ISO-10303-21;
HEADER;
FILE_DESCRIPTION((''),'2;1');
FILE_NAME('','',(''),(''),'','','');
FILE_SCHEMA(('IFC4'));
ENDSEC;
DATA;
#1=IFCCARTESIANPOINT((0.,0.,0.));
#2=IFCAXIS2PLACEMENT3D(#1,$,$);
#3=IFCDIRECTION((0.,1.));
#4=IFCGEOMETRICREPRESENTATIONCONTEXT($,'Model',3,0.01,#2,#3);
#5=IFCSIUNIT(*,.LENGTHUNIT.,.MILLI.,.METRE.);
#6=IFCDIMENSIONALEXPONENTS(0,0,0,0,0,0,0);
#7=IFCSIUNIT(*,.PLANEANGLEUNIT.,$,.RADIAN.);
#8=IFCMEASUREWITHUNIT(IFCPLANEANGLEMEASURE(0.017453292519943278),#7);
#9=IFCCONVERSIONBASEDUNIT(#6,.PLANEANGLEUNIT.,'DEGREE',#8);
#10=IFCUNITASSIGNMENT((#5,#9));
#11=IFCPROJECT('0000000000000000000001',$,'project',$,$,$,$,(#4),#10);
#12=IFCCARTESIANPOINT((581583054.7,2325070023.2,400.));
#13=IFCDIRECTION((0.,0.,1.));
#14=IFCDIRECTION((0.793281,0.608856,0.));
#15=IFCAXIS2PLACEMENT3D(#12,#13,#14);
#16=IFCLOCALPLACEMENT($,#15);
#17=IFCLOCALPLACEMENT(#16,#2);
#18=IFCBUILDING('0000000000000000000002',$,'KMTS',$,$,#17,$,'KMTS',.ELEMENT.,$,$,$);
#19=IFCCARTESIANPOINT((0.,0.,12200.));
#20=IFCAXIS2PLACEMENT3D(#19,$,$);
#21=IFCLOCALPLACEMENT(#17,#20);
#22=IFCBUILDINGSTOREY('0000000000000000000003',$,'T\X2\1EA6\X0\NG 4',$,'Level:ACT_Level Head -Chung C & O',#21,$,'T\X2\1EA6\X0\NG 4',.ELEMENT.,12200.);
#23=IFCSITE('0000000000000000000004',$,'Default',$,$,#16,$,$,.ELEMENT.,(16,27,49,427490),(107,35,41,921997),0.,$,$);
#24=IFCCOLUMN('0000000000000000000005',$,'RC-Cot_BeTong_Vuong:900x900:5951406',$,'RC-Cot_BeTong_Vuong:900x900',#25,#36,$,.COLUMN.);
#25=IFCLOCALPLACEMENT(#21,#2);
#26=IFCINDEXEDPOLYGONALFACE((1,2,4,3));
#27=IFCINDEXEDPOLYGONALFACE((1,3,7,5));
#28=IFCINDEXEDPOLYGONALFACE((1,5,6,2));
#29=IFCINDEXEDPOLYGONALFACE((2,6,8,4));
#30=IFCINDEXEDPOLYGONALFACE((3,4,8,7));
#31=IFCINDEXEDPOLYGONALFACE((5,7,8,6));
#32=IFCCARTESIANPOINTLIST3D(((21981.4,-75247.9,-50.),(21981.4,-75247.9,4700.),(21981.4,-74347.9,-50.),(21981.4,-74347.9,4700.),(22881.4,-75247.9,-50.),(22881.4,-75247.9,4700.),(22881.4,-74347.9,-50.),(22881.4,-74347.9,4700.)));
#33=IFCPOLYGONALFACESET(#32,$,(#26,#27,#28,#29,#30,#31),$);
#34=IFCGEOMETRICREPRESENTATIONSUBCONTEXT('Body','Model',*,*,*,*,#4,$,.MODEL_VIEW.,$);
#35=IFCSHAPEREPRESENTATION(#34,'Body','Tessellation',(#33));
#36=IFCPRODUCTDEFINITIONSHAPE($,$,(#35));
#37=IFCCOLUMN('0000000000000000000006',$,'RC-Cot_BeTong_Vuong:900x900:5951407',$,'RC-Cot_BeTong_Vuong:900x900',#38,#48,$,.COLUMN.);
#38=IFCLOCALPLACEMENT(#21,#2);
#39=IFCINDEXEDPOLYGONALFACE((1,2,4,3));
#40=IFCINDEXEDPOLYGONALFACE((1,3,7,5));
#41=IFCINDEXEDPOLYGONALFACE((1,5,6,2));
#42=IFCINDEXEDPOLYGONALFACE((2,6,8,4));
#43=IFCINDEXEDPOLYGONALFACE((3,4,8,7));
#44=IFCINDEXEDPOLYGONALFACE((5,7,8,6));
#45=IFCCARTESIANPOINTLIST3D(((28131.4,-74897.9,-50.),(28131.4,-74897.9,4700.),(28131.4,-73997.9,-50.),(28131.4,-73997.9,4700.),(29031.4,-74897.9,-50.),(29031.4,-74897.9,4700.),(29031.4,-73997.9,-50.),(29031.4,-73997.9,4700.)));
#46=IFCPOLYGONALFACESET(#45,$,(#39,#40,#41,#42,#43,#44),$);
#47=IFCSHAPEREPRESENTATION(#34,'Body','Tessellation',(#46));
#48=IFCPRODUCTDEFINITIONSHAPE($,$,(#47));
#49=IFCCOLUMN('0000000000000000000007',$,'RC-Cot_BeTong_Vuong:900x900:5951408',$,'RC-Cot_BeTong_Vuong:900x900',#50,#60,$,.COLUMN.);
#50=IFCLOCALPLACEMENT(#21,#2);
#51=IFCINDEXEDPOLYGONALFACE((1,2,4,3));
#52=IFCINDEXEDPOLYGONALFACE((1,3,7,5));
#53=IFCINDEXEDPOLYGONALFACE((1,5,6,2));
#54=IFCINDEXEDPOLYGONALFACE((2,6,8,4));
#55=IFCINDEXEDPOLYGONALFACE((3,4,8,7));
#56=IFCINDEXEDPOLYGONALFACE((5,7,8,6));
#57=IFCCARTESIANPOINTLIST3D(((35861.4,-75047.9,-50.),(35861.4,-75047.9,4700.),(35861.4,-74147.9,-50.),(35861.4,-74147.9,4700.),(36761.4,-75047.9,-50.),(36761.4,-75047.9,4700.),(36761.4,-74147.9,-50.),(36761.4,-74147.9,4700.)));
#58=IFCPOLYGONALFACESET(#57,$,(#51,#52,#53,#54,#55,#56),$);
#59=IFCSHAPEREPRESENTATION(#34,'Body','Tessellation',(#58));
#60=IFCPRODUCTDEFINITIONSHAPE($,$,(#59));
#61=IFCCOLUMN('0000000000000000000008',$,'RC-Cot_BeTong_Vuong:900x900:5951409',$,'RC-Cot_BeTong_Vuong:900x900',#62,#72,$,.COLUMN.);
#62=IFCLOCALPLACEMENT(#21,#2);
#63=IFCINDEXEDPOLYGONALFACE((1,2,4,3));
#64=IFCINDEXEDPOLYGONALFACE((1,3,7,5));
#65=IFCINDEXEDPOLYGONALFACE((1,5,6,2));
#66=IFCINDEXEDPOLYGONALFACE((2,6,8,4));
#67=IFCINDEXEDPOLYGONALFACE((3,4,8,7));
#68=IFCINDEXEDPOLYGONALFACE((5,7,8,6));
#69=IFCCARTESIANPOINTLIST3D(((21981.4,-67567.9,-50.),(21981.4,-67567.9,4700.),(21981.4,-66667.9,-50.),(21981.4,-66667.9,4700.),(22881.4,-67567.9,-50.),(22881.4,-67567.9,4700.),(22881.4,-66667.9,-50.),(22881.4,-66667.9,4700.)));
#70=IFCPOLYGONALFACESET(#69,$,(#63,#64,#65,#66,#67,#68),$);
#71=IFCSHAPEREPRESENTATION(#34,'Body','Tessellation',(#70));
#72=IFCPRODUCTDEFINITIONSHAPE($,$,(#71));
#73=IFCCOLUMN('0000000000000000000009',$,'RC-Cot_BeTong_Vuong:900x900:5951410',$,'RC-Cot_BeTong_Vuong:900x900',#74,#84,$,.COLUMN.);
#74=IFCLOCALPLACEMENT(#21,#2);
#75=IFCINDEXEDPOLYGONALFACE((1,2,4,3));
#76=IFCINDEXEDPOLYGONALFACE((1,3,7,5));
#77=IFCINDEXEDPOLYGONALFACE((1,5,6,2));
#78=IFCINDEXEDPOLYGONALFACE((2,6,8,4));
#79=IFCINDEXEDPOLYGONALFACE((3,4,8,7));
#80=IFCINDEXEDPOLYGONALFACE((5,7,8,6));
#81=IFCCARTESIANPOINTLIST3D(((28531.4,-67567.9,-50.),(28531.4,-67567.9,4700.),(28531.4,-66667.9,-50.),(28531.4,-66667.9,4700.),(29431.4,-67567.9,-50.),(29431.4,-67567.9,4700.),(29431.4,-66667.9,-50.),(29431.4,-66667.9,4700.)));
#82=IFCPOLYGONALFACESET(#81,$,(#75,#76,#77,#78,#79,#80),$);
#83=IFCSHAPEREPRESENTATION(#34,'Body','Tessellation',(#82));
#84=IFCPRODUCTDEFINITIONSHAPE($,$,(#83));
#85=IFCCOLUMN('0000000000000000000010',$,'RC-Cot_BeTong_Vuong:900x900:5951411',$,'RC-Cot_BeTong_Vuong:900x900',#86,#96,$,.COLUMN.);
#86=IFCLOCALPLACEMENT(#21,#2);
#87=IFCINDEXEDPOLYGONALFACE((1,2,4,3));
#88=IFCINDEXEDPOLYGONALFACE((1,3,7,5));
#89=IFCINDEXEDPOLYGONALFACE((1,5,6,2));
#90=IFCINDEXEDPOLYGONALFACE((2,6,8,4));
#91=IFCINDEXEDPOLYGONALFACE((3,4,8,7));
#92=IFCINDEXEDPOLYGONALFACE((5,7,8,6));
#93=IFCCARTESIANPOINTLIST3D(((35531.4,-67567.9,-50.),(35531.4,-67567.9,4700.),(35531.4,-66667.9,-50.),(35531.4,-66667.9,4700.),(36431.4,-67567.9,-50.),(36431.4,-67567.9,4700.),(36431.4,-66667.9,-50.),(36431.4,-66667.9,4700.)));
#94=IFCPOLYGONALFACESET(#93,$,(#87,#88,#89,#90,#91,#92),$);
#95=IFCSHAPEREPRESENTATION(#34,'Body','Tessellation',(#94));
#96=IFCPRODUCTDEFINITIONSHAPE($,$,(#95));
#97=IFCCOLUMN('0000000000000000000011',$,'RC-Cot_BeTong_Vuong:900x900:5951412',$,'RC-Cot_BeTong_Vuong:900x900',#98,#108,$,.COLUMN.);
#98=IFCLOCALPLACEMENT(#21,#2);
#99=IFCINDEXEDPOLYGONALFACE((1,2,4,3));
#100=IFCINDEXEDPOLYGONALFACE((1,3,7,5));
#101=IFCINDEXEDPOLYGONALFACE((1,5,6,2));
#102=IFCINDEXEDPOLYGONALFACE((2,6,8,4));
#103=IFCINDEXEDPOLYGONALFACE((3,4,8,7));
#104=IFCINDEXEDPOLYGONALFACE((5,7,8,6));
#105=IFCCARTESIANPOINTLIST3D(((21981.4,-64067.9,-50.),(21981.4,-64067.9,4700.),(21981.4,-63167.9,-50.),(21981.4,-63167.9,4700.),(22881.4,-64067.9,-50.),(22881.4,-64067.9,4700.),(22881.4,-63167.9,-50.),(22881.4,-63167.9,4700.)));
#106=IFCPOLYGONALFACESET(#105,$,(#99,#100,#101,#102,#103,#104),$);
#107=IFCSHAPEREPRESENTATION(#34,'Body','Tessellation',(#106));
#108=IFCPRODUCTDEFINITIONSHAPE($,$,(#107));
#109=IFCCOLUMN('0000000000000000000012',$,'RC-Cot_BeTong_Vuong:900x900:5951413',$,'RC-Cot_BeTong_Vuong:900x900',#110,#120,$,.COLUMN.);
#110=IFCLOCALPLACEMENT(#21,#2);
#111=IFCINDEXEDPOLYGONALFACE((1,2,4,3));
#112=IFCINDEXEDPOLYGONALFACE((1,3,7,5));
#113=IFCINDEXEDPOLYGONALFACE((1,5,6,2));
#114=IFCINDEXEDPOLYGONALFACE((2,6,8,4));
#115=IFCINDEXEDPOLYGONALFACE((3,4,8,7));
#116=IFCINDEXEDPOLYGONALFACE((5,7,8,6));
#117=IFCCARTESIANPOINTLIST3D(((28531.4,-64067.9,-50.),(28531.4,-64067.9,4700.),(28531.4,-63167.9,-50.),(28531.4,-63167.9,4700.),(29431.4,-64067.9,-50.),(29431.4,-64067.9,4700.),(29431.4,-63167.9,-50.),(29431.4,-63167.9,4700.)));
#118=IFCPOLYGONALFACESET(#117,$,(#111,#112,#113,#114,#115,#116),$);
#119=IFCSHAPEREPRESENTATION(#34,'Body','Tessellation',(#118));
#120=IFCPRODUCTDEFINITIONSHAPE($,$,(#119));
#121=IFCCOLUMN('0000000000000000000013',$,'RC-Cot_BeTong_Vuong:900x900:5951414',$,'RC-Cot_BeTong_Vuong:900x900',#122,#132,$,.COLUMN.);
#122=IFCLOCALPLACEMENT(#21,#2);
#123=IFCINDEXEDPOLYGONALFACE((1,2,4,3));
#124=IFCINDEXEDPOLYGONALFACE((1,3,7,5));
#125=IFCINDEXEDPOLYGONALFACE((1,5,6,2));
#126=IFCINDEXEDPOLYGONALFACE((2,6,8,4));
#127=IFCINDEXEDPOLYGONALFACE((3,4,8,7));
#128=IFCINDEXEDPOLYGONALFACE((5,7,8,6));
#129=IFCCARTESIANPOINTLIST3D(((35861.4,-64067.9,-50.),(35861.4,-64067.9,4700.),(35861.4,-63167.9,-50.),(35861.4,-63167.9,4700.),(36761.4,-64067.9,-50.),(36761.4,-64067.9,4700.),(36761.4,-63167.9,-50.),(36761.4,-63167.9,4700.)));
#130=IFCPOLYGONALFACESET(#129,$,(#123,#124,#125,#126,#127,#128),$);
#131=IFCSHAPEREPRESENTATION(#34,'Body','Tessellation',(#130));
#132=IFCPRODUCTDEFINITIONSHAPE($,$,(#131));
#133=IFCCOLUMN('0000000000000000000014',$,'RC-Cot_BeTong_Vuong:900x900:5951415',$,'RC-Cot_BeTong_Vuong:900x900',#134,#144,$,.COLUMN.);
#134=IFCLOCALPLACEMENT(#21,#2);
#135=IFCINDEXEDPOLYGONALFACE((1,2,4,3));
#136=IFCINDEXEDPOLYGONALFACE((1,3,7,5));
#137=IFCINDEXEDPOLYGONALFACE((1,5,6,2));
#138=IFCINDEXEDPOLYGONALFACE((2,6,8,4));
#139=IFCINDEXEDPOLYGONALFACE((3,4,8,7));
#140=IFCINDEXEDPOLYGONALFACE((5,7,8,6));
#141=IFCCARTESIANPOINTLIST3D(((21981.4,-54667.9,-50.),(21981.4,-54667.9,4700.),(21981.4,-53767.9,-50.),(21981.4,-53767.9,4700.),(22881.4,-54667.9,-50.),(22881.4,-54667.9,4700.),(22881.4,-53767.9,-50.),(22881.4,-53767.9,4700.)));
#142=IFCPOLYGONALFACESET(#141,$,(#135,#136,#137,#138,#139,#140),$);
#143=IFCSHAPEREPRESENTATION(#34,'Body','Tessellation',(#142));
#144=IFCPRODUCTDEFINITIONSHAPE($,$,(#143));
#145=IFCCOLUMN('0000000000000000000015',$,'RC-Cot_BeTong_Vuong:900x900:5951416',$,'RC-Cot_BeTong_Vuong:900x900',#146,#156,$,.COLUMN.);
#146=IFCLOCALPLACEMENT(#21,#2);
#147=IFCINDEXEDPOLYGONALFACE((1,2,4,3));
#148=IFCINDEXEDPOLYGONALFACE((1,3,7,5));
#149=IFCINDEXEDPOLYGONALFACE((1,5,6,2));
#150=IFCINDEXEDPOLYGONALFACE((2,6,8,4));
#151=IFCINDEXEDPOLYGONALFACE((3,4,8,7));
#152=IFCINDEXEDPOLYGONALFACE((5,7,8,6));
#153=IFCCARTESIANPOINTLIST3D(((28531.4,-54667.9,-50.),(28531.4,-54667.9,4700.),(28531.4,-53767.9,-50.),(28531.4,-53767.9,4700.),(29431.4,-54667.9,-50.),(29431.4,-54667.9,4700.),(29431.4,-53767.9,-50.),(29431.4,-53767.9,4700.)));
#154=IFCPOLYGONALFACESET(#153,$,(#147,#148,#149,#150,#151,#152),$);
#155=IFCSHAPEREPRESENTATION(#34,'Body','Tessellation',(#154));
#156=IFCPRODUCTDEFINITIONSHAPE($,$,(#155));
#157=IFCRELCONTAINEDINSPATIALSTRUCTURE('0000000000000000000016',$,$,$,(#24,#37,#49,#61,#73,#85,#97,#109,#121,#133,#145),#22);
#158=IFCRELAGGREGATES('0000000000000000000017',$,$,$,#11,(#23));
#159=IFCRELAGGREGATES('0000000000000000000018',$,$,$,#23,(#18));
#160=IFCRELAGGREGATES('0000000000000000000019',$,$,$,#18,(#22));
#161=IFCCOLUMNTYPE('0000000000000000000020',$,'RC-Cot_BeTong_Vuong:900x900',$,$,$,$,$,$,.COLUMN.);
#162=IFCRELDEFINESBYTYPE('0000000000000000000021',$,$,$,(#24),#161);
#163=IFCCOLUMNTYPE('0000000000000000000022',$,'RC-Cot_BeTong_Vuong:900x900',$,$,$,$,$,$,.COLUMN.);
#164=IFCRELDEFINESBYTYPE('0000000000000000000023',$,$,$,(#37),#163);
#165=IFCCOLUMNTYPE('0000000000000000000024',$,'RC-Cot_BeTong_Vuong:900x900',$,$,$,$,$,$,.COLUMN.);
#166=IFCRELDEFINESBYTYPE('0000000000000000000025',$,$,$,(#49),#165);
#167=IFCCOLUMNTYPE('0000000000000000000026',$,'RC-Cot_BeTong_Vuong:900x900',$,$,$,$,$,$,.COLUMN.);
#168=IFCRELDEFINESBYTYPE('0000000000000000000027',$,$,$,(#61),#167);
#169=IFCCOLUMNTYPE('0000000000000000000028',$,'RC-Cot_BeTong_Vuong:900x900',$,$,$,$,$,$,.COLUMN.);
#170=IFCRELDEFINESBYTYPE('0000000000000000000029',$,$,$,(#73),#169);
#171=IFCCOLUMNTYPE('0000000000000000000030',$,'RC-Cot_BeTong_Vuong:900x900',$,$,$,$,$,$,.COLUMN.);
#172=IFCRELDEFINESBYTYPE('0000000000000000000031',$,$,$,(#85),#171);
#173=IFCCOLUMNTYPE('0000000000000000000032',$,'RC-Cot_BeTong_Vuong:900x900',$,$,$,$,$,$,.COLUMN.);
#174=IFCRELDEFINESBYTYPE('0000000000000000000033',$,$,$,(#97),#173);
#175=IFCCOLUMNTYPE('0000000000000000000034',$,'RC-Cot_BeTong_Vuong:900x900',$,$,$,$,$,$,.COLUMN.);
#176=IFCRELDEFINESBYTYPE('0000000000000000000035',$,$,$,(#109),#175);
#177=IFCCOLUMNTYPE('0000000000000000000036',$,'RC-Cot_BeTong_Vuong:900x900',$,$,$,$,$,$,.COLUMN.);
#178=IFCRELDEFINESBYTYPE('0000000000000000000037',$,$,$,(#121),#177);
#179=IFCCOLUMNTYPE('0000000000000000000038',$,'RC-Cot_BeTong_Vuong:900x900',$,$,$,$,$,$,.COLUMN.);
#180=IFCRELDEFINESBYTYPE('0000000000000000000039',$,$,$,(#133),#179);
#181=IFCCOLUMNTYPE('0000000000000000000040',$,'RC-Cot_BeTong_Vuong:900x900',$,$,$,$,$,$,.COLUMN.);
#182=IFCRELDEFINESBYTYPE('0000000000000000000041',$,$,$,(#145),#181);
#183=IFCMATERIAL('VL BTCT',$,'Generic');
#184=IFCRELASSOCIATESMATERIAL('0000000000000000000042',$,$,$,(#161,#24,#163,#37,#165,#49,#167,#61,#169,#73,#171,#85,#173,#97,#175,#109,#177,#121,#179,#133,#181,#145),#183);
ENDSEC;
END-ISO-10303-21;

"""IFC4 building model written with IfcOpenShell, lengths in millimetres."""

from ifc_helpers import new_model, entity, si_unit, converted_unit, direction, frame, origin, place, context, subcontext, project, spatial, indexed_curve, outline, extrude, source, transform, mapped, material, type_object, type_shapes, element, save


model = new_model("IFC4")

# Units and contexts
model_context = context("Model", 3, precision=0.01, world=origin(), true_north=direction((0.0, 1.0)))
body_context = subcontext(model_context, "Body", "Model", "MODEL_VIEW")
ifc_project = project(units=[si_unit("LENGTHUNIT", "METRE", prefix="MILLI"), converted_unit("PLANEANGLEUNIT", "DEGREE", entity("IfcPlaneAngleMeasure", 0.017453292519943278), si_unit("PLANEANGLEUNIT", "RADIAN"), dimensions=[0, 0, 0, 0, 0, 0, 0])], contexts=[model_context])

# Site, building, storey
site_placement = place(None, frame((581583054.7, 2325070023.2, 400.0), z_axis=(0.0, 0.0, 1.0), x_axis=(0.793281, 0.608856, 0.0)))
site = spatial("IfcSite", under=ifc_project, at=site_placement, Name="Default", CompositionType="ELEMENT", RefLatitude=(16, 27, 49, 427490), RefLongitude=(107, 35, 41, 921997), RefElevation=0.0)
building_placement = place(site_placement, origin())
building = spatial("IfcBuilding", under=site, at=building_placement, Name="KMTS", LongName="KMTS", CompositionType="ELEMENT")
storey_placement = place(building_placement, frame((0.0, 0.0, 12200.0)))
storey = spatial("IfcBuildingStorey", under=building, at=storey_placement, Name="TẦNG 4", ObjectType="Level:ACT_Level Head -Chung C & O", LongName="TẦNG 4", CompositionType="ELEMENT", Elevation=12200.0)

# Columns
ifc_material_1 = material(Name="VL BTCT", Category="Generic")
column_type_1 = type_object("IfcColumnType", Name="RC-Cot_BeTong_Vuong:900x900", PredefinedType="COLUMN", material=ifc_material_1)
shared_shape_1 = source(origin(), body_context, "Body", "SweptSolid", [
    extrude(outline(indexed_curve([(-450.0, -450.0), (450.0, -450.0), (450.0, 450.0), (-450.0, 450.0), (-450.0, -450.0)], self_intersect=False)), frame((22431.4, -74797.9, 12150.0), z_axis=(0.0, 0.0, 1.0), x_axis=(-1.0, 0.0, 0.0)), (0.0, 0.0, 1.0), 4750.0),
])
type_shapes(column_type_1, [shared_shape_1])
column_1_placement = place(storey_placement, frame((0.0, 0.0, -12200.0)))
element("IfcColumn", 1, at=column_1_placement, inside=storey, type_object=column_type_1, material=ifc_material_1, Name="RC-Cot_BeTong_Vuong:900x900:5951406", ObjectType="RC-Cot_BeTong_Vuong:900x900", PredefinedType="COLUMN", context=body_context, shape_type="MappedRepresentation", body=[
    mapped(shared_shape_1, transform((0.0, 0.0, 0.0), scale=1.0)),
])
column_type_2 = type_object("IfcColumnType", Name="RC-Cot_BeTong_Vuong:900x900", PredefinedType="COLUMN", material=ifc_material_1)
shared_shape_2 = source(origin(), body_context, "Body", "SweptSolid", [
    extrude(outline(indexed_curve([(-450.0, -450.0), (450.0, -450.0), (450.0, 450.0), (-450.0, 450.0), (-450.0, -450.0)], self_intersect=False)), frame((28581.4, -74447.9, 12150.0), z_axis=(0.0, 0.0, 1.0), x_axis=(-1.0, 0.0, 0.0)), (0.0, 0.0, 1.0), 4750.0),
])
type_shapes(column_type_2, [shared_shape_2])
column_2_placement = place(storey_placement, frame((0.0, 0.0, -12200.0)))
element("IfcColumn", 2, at=column_2_placement, inside=storey, type_object=column_type_2, material=ifc_material_1, Name="RC-Cot_BeTong_Vuong:900x900:5951407", ObjectType="RC-Cot_BeTong_Vuong:900x900", PredefinedType="COLUMN", context=body_context, shape_type="MappedRepresentation", body=[
    mapped(shared_shape_2, transform((0.0, 0.0, 0.0), scale=1.0)),
])
column_type_3 = type_object("IfcColumnType", Name="RC-Cot_BeTong_Vuong:900x900", PredefinedType="COLUMN", material=ifc_material_1)
shared_shape_3 = source(origin(), body_context, "Body", "SweptSolid", [
    extrude(outline(indexed_curve([(-450.0, -450.0), (450.0, -450.0), (450.0, 450.0), (-450.0, 450.0), (-450.0, -450.0)], self_intersect=False)), frame((36311.4, -74597.9, 12150.0), z_axis=(0.0, 0.0, 1.0), x_axis=(-1.0, 0.0, 0.0)), (0.0, 0.0, 1.0), 4750.0),
])
type_shapes(column_type_3, [shared_shape_3])
column_3_placement = place(storey_placement, frame((0.0, 0.0, -12200.0)))
element("IfcColumn", 3, at=column_3_placement, inside=storey, type_object=column_type_3, material=ifc_material_1, Name="RC-Cot_BeTong_Vuong:900x900:5951408", ObjectType="RC-Cot_BeTong_Vuong:900x900", PredefinedType="COLUMN", context=body_context, shape_type="MappedRepresentation", body=[
    mapped(shared_shape_3, transform((0.0, 0.0, 0.0), scale=1.0)),
])
column_type_4 = type_object("IfcColumnType", Name="RC-Cot_BeTong_Vuong:900x900", PredefinedType="COLUMN", material=ifc_material_1)
shared_shape_4 = source(origin(), body_context, "Body", "SweptSolid", [
    extrude(outline(indexed_curve([(-450.0, -450.0), (450.0, -450.0), (450.0, 450.0), (-450.0, 450.0), (-450.0, -450.0)], self_intersect=False)), frame((22431.4, -67117.9, 12150.0), z_axis=(0.0, 0.0, 1.0), x_axis=(-1.0, 0.0, 0.0)), (0.0, 0.0, 1.0), 4750.0),
])
type_shapes(column_type_4, [shared_shape_4])
column_4_placement = place(storey_placement, frame((0.0, 0.0, -12200.0)))
element("IfcColumn", 4, at=column_4_placement, inside=storey, type_object=column_type_4, material=ifc_material_1, Name="RC-Cot_BeTong_Vuong:900x900:5951409", ObjectType="RC-Cot_BeTong_Vuong:900x900", PredefinedType="COLUMN", context=body_context, shape_type="MappedRepresentation", body=[
    mapped(shared_shape_4, transform((0.0, 0.0, 0.0), scale=1.0)),
])
column_type_5 = type_object("IfcColumnType", Name="RC-Cot_BeTong_Vuong:900x900", PredefinedType="COLUMN", material=ifc_material_1)
shared_shape_5 = source(origin(), body_context, "Body", "SweptSolid", [
    extrude(outline(indexed_curve([(-450.0, -450.0), (450.0, -450.0), (450.0, 450.0), (-450.0, 450.0), (-450.0, -450.0)], self_intersect=False)), frame((28981.4, -67117.9, 12150.0), z_axis=(0.0, 0.0, 1.0), x_axis=(-1.0, 0.0, 0.0)), (0.0, 0.0, 1.0), 4750.0),
])
type_shapes(column_type_5, [shared_shape_5])
column_5_placement = place(storey_placement, frame((0.0, 0.0, -12200.0)))
element("IfcColumn", 5, at=column_5_placement, inside=storey, type_object=column_type_5, material=ifc_material_1, Name="RC-Cot_BeTong_Vuong:900x900:5951410", ObjectType="RC-Cot_BeTong_Vuong:900x900", PredefinedType="COLUMN", context=body_context, shape_type="MappedRepresentation", body=[
    mapped(shared_shape_5, transform((0.0, 0.0, 0.0), scale=1.0)),
])
column_type_6 = type_object("IfcColumnType", Name="RC-Cot_BeTong_Vuong:900x900", PredefinedType="COLUMN", material=ifc_material_1)
shared_shape_6 = source(origin(), body_context, "Body", "SweptSolid", [
    extrude(outline(indexed_curve([(-450.0, -450.0), (450.0, -450.0), (450.0, 450.0), (-450.0, 450.0), (-450.0, -450.0)], self_intersect=False)), frame((35981.4, -67117.9, 12150.0), z_axis=(0.0, 0.0, 1.0), x_axis=(-1.0, 0.0, 0.0)), (0.0, 0.0, 1.0), 4750.0),
])
type_shapes(column_type_6, [shared_shape_6])
column_6_placement = place(storey_placement, frame((0.0, 0.0, -12200.0)))
element("IfcColumn", 6, at=column_6_placement, inside=storey, type_object=column_type_6, material=ifc_material_1, Name="RC-Cot_BeTong_Vuong:900x900:5951411", ObjectType="RC-Cot_BeTong_Vuong:900x900", PredefinedType="COLUMN", context=body_context, shape_type="MappedRepresentation", body=[
    mapped(shared_shape_6, transform((0.0, 0.0, 0.0), scale=1.0)),
])
column_type_7 = type_object("IfcColumnType", Name="RC-Cot_BeTong_Vuong:900x900", PredefinedType="COLUMN", material=ifc_material_1)
shared_shape_7 = source(origin(), body_context, "Body", "SweptSolid", [
    extrude(outline(indexed_curve([(-450.0, -450.0), (450.0, -450.0), (450.0, 450.0), (-450.0, 450.0), (-450.0, -450.0)], self_intersect=False)), frame((22431.4, -63617.9, 12150.0), z_axis=(0.0, 0.0, 1.0), x_axis=(-1.0, 0.0, 0.0)), (0.0, 0.0, 1.0), 4750.0),
])
type_shapes(column_type_7, [shared_shape_7])
column_7_placement = place(storey_placement, frame((0.0, 0.0, -12200.0)))
element("IfcColumn", 7, at=column_7_placement, inside=storey, type_object=column_type_7, material=ifc_material_1, Name="RC-Cot_BeTong_Vuong:900x900:5951412", ObjectType="RC-Cot_BeTong_Vuong:900x900", PredefinedType="COLUMN", context=body_context, shape_type="MappedRepresentation", body=[
    mapped(shared_shape_7, transform((0.0, 0.0, 0.0), scale=1.0)),
])
column_type_8 = type_object("IfcColumnType", Name="RC-Cot_BeTong_Vuong:900x900", PredefinedType="COLUMN", material=ifc_material_1)
shared_shape_8 = source(origin(), body_context, "Body", "SweptSolid", [
    extrude(outline(indexed_curve([(-450.0, -450.0), (450.0, -450.0), (450.0, 450.0), (-450.0, 450.0), (-450.0, -450.0)], self_intersect=False)), frame((28981.4, -63617.9, 12150.0), z_axis=(0.0, 0.0, 1.0), x_axis=(-1.0, 0.0, 0.0)), (0.0, 0.0, 1.0), 4750.0),
])
type_shapes(column_type_8, [shared_shape_8])
column_8_placement = place(storey_placement, frame((0.0, 0.0, -12200.0)))
element("IfcColumn", 8, at=column_8_placement, inside=storey, type_object=column_type_8, material=ifc_material_1, Name="RC-Cot_BeTong_Vuong:900x900:5951413", ObjectType="RC-Cot_BeTong_Vuong:900x900", PredefinedType="COLUMN", context=body_context, shape_type="MappedRepresentation", body=[
    mapped(shared_shape_8, transform((0.0, 0.0, 0.0), scale=1.0)),
])
column_type_9 = type_object("IfcColumnType", Name="RC-Cot_BeTong_Vuong:900x900", PredefinedType="COLUMN", material=ifc_material_1)
shared_shape_9 = source(origin(), body_context, "Body", "SweptSolid", [
    extrude(outline(indexed_curve([(-450.0, -450.0), (450.0, -450.0), (450.0, 450.0), (-450.0, 450.0), (-450.0, -450.0)], self_intersect=False)), frame((36311.4, -63617.9, 12150.0), z_axis=(0.0, 0.0, 1.0), x_axis=(-1.0, 0.0, 0.0)), (0.0, 0.0, 1.0), 4750.0),
])
type_shapes(column_type_9, [shared_shape_9])
column_9_placement = place(storey_placement, frame((0.0, 0.0, -12200.0)))
element("IfcColumn", 9, at=column_9_placement, inside=storey, type_object=column_type_9, material=ifc_material_1, Name="RC-Cot_BeTong_Vuong:900x900:5951414", ObjectType="RC-Cot_BeTong_Vuong:900x900", PredefinedType="COLUMN", context=body_context, shape_type="MappedRepresentation", body=[
    mapped(shared_shape_9, transform((0.0, 0.0, 0.0), scale=1.0)),
])
column_type_10 = type_object("IfcColumnType", Name="RC-Cot_BeTong_Vuong:900x900", PredefinedType="COLUMN", material=ifc_material_1)
shared_shape_10 = source(origin(), body_context, "Body", "SweptSolid", [
    extrude(outline(indexed_curve([(-450.0, -450.0), (450.0, -450.0), (450.0, 450.0), (-450.0, 450.0), (-450.0, -450.0)], self_intersect=False)), frame((22431.4, -54217.9, 12150.0), z_axis=(0.0, 0.0, 1.0), x_axis=(-1.0, 0.0, 0.0)), (0.0, 0.0, 1.0), 4750.0),
])
type_shapes(column_type_10, [shared_shape_10])
column_10_placement = place(storey_placement, frame((0.0, 0.0, -12200.0)))
element("IfcColumn", 10, at=column_10_placement, inside=storey, type_object=column_type_10, material=ifc_material_1, Name="RC-Cot_BeTong_Vuong:900x900:5951415", ObjectType="RC-Cot_BeTong_Vuong:900x900", PredefinedType="COLUMN", context=body_context, shape_type="MappedRepresentation", body=[
    mapped(shared_shape_10, transform((0.0, 0.0, 0.0), scale=1.0)),
])
column_type_11 = type_object("IfcColumnType", Name="RC-Cot_BeTong_Vuong:900x900", PredefinedType="COLUMN", material=ifc_material_1)
shared_shape_11 = source(origin(), body_context, "Body", "SweptSolid", [
    extrude(outline(indexed_curve([(-450.0, -450.0), (450.0, -450.0), (450.0, 450.0), (-450.0, 450.0), (-450.0, -450.0)], self_intersect=False)), frame((28981.4, -54217.9, 12150.0), z_axis=(0.0, 0.0, 1.0), x_axis=(-1.0, 0.0, 0.0)), (0.0, 0.0, 1.0), 4750.0),
])
type_shapes(column_type_11, [shared_shape_11])
column_11_placement = place(storey_placement, frame((0.0, 0.0, -12200.0)))
element("IfcColumn", 11, at=column_11_placement, inside=storey, type_object=column_type_11, material=ifc_material_1, Name="RC-Cot_BeTong_Vuong:900x900:5951416", ObjectType="RC-Cot_BeTong_Vuong:900x900", PredefinedType="COLUMN", context=body_context, shape_type="MappedRepresentation", body=[
    mapped(shared_shape_11, transform((0.0, 0.0, 0.0), scale=1.0)),
])

save(model, "model.ifc")
